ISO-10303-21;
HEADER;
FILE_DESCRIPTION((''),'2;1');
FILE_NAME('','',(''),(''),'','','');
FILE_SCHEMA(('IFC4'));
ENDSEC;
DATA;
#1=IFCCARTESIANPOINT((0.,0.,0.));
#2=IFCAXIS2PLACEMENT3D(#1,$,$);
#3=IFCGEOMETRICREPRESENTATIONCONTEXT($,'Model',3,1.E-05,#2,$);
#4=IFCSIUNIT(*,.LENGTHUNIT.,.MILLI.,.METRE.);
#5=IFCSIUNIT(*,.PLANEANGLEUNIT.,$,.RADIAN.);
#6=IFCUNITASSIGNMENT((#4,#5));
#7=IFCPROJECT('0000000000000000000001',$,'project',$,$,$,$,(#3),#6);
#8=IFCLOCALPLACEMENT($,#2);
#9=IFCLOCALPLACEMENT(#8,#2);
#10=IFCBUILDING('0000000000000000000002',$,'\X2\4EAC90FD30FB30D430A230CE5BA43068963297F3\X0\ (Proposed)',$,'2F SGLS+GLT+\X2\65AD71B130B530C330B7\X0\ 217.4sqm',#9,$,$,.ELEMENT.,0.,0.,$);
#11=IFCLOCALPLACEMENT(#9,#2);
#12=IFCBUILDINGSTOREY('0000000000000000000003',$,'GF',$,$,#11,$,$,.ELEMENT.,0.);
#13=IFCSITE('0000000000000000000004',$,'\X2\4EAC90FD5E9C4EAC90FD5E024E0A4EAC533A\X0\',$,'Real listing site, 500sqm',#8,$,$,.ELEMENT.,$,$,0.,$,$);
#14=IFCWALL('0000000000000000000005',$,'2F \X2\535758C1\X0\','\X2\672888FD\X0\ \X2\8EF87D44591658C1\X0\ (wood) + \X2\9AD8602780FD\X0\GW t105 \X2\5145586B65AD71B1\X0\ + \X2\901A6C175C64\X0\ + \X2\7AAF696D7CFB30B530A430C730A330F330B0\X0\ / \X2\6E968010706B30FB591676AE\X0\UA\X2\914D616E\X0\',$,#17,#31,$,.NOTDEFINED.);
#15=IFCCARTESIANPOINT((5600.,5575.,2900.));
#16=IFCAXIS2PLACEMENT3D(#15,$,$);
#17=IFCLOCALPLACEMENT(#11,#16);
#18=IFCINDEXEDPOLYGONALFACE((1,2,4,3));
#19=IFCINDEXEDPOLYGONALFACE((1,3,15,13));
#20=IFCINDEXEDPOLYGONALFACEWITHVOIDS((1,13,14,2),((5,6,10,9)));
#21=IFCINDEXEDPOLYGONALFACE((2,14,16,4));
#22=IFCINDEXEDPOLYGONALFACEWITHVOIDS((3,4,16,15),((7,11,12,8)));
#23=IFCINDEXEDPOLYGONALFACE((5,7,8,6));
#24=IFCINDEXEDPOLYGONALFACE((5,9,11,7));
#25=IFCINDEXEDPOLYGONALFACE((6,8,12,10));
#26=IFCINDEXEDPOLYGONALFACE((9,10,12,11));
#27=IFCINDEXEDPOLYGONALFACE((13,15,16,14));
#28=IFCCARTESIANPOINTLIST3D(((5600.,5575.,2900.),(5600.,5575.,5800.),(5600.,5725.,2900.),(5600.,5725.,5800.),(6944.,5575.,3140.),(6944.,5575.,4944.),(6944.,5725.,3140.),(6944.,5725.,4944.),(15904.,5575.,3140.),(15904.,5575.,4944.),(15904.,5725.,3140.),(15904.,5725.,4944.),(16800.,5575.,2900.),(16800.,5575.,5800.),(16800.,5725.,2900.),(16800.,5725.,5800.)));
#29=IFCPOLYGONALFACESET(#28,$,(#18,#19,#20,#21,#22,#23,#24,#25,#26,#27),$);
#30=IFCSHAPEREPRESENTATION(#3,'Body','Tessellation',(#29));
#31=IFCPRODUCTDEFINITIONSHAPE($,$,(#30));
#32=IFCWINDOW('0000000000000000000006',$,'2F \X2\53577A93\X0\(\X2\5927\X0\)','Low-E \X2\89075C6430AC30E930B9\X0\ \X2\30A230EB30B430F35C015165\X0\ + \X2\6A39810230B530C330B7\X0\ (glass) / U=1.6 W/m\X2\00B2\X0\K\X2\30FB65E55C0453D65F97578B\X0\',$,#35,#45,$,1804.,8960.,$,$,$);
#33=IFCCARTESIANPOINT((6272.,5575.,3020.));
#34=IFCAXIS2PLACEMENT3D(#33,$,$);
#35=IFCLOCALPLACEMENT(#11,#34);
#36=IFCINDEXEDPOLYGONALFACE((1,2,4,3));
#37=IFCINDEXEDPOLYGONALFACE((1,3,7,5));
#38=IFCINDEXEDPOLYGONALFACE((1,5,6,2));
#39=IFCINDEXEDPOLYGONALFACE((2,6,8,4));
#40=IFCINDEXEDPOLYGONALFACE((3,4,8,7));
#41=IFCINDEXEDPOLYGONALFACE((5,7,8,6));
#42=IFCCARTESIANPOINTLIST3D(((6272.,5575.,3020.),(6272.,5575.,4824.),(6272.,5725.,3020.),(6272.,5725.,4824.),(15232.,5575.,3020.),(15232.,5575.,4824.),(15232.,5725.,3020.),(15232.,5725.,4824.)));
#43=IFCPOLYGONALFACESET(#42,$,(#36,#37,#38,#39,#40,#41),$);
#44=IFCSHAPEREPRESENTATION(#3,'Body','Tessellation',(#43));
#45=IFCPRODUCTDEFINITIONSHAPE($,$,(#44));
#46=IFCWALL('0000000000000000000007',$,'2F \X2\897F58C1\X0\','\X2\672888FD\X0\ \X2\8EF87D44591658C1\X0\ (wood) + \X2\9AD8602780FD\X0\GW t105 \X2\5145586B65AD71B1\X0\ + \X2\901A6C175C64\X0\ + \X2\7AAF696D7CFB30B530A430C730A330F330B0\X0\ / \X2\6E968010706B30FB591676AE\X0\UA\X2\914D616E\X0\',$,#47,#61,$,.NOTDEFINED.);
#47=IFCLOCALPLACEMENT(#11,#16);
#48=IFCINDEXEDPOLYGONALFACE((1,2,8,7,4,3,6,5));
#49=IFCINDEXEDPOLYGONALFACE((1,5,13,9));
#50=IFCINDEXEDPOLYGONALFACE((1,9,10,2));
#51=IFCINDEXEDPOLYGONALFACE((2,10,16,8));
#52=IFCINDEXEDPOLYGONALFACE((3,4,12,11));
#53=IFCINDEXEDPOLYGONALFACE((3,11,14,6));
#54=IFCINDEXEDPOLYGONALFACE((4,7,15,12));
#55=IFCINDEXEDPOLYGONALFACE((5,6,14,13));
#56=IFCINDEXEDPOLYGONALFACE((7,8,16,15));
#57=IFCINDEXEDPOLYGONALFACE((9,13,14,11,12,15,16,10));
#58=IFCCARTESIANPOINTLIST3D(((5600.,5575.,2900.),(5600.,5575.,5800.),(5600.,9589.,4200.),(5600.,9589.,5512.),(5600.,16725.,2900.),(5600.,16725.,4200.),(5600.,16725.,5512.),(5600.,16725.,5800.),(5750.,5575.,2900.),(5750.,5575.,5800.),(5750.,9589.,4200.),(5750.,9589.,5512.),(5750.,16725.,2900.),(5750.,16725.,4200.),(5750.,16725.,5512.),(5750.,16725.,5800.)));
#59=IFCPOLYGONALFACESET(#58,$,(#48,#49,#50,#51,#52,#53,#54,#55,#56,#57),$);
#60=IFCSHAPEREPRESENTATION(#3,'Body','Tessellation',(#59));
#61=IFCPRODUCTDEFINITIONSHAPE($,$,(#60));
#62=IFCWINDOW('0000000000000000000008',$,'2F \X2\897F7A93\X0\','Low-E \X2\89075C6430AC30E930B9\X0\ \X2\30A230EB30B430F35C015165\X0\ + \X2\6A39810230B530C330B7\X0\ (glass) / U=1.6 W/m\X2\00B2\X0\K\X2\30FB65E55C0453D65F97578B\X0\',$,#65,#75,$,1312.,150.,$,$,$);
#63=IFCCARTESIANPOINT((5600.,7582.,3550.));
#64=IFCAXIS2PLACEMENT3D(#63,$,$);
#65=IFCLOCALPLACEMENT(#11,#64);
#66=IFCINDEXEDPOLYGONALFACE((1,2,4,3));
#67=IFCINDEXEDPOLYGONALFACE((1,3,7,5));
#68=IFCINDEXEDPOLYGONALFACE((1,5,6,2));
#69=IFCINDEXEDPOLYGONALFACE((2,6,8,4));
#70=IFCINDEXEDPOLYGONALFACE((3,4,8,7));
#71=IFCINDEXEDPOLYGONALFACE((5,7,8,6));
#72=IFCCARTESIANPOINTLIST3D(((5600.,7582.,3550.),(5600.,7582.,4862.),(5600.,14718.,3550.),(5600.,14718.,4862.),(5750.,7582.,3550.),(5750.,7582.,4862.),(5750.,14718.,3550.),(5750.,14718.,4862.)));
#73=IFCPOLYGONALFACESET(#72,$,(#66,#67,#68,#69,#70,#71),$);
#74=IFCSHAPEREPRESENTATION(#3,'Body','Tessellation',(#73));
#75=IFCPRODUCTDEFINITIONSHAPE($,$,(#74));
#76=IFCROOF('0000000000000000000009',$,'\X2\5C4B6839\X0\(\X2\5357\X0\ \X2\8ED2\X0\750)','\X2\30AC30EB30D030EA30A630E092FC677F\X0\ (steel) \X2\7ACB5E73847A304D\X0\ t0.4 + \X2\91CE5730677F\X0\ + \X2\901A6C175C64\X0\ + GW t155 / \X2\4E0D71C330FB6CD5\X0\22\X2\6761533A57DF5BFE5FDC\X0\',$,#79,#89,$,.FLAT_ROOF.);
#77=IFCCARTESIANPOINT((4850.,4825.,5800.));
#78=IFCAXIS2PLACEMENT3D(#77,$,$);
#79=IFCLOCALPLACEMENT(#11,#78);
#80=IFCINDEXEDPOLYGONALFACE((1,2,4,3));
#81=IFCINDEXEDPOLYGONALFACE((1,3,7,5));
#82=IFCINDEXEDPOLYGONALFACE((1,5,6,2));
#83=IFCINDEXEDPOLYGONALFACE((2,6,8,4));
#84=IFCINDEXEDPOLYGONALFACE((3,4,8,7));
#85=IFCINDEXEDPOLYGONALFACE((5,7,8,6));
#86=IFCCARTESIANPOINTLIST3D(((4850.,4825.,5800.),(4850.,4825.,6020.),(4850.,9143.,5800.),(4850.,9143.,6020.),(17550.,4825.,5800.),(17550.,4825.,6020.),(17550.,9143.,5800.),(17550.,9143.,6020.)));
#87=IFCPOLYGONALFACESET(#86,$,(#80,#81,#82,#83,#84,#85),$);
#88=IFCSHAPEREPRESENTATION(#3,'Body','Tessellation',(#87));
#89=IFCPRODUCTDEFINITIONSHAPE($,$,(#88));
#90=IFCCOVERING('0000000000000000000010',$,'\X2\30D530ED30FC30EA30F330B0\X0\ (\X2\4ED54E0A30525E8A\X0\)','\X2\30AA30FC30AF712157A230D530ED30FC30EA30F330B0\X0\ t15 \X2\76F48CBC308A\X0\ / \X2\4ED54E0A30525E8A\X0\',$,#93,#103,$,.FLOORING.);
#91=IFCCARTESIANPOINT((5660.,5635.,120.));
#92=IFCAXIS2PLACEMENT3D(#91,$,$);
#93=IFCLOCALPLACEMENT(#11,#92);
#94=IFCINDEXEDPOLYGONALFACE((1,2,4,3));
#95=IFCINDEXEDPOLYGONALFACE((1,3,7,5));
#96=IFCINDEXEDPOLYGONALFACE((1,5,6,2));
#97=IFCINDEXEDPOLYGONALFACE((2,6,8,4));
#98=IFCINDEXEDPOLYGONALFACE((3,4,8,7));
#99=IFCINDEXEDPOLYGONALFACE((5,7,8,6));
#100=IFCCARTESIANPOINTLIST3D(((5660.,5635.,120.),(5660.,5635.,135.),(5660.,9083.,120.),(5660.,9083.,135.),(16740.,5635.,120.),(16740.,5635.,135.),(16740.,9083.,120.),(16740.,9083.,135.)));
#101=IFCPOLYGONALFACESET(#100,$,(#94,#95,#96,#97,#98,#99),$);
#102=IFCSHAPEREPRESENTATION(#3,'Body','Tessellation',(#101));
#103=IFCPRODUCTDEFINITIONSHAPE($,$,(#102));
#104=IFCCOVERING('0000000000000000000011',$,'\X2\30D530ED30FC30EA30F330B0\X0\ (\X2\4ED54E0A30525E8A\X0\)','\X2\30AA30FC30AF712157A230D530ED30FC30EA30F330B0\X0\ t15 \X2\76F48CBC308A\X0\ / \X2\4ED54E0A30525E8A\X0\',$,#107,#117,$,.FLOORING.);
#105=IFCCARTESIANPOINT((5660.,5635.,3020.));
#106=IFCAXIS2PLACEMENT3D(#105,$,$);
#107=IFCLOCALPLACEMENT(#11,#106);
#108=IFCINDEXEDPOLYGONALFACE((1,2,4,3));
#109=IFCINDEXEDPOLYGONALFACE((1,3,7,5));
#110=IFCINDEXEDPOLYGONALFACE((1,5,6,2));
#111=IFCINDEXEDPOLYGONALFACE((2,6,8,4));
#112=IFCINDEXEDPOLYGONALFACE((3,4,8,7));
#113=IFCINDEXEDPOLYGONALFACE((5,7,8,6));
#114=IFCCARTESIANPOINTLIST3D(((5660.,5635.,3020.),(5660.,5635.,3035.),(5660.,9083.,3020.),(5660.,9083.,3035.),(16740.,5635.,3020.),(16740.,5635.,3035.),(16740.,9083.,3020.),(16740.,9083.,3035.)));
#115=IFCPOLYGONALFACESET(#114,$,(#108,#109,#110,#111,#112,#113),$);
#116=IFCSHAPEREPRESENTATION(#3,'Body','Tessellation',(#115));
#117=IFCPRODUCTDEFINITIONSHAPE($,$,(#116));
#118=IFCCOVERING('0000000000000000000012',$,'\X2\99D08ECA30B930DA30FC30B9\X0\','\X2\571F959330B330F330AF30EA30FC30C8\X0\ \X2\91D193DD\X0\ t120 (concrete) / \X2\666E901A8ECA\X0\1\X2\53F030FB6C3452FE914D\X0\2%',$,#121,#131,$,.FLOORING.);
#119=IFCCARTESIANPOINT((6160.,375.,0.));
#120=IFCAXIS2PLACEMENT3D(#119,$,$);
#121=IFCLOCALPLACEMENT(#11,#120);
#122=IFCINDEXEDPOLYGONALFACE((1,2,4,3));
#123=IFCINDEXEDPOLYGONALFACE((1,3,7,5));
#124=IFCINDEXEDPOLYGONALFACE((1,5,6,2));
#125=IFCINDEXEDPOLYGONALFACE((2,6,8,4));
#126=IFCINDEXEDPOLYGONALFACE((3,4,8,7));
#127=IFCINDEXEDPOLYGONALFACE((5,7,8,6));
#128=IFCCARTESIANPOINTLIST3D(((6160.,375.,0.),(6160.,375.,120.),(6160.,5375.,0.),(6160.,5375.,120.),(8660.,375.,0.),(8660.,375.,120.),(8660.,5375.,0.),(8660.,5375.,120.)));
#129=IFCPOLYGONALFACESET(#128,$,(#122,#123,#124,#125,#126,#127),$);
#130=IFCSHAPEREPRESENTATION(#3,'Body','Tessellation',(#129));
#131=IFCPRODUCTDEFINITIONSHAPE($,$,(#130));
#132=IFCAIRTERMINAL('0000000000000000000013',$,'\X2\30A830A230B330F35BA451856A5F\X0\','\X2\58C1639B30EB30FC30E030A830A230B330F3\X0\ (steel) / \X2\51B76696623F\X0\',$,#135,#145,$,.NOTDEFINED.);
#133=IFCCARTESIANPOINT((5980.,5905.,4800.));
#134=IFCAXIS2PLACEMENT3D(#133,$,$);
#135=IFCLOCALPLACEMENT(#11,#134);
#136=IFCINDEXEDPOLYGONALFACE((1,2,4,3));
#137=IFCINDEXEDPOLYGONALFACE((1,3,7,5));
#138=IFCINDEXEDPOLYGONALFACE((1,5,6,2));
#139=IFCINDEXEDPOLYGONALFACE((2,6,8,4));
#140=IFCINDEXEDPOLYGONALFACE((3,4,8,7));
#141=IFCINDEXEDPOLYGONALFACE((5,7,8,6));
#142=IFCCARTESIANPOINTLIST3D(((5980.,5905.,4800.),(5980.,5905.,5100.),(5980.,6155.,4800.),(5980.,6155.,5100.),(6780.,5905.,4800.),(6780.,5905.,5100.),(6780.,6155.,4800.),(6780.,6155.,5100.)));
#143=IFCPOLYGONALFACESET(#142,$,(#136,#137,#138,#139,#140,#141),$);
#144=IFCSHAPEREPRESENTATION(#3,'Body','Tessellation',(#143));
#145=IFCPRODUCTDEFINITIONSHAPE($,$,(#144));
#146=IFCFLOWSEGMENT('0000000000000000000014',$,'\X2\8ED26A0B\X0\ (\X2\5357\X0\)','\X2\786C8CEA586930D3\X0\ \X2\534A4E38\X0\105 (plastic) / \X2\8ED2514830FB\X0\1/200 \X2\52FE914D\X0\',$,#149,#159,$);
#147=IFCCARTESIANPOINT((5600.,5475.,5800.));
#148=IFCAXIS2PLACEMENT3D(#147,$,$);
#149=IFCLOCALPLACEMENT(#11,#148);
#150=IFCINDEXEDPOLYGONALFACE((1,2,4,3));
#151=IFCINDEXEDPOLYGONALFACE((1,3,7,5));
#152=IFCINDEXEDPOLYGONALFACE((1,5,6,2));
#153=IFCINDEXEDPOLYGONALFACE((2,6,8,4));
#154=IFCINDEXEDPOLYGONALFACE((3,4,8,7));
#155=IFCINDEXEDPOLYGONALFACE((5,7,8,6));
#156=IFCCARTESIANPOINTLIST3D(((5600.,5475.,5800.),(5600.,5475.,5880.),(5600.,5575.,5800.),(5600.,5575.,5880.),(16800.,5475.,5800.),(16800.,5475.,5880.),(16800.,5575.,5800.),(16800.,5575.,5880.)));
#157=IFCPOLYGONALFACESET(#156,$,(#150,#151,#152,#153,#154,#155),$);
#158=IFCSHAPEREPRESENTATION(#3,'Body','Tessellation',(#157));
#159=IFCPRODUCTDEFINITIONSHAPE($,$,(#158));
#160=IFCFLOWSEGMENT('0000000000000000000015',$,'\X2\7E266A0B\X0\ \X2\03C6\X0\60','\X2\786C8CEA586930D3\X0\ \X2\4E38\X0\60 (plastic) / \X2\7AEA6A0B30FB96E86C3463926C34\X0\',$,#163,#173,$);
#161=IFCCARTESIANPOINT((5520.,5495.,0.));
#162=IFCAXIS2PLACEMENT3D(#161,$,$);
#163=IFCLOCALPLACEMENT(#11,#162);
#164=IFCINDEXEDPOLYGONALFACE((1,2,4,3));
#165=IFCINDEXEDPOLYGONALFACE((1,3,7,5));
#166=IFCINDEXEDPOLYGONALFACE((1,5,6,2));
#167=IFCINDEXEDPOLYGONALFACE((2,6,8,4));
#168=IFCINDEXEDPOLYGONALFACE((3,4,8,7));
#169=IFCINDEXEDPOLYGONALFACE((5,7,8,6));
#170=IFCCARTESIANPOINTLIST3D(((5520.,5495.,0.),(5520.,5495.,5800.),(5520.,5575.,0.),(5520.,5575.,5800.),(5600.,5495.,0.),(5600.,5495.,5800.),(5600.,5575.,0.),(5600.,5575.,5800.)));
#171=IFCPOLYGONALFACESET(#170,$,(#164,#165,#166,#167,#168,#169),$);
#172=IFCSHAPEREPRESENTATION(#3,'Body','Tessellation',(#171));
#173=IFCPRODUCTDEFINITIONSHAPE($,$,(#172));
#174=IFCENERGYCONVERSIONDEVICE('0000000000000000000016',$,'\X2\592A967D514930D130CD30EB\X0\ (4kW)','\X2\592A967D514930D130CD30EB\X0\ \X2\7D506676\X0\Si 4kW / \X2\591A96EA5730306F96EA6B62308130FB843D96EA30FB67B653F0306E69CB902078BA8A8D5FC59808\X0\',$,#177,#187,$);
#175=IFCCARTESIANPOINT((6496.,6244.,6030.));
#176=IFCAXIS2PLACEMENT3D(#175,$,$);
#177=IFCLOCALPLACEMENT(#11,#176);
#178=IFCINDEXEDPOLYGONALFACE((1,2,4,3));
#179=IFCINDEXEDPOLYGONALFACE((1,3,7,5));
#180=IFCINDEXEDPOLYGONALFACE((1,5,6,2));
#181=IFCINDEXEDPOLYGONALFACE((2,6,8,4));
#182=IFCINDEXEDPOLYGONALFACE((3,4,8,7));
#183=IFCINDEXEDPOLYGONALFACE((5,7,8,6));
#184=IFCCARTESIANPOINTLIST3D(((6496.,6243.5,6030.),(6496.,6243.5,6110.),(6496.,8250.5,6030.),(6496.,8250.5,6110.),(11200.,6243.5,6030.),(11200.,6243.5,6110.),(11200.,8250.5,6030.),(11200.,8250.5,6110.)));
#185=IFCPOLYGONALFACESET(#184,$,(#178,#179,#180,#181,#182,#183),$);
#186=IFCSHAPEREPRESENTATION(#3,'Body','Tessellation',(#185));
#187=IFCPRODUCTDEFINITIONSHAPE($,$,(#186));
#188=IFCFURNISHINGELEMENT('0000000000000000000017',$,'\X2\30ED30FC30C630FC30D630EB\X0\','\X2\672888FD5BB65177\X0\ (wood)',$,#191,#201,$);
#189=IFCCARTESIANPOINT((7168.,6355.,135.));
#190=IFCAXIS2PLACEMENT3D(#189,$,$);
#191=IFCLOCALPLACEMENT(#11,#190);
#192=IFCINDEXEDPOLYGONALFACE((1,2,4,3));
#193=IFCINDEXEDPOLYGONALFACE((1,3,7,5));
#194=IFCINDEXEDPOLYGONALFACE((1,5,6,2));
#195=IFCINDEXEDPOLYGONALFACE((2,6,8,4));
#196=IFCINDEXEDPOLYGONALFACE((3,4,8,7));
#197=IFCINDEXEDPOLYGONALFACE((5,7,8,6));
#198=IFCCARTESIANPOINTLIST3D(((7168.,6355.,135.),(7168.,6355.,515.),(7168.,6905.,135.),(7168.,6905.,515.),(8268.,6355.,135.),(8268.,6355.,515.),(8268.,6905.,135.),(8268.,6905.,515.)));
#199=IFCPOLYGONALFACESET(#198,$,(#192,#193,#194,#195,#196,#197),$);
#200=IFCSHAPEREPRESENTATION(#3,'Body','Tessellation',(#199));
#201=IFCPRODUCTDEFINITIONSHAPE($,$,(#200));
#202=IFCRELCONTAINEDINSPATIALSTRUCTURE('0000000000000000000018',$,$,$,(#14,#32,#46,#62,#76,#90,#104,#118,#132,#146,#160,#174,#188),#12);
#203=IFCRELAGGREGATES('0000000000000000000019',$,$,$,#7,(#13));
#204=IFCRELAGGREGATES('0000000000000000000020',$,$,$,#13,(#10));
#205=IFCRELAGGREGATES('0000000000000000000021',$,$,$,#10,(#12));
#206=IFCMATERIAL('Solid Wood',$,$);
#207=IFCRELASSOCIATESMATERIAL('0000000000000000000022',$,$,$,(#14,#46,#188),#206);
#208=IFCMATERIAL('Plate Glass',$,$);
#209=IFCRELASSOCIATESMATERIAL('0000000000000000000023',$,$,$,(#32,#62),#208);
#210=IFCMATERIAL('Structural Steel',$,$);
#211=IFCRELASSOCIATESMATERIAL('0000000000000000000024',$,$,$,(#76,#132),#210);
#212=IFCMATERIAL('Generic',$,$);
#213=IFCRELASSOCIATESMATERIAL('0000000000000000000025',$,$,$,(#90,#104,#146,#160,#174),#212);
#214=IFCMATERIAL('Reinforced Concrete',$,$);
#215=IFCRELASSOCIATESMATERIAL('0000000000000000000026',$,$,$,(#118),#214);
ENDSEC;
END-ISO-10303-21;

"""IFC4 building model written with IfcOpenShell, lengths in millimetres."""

from ifc_helpers import new_model, si_unit, frame, frame_2d, origin, place, context, project, spatial, rectangle, extrude, material, element, fill, save


model = new_model("IFC4")

# Units and contexts
model_context = context("Model", 3, precision=1e-05, world=origin())
ifc_project = project(units=[si_unit("LENGTHUNIT", "METRE", prefix="MILLI"), si_unit("PLANEANGLEUNIT", "RADIAN")], contexts=[model_context])

# Site, building, storey
site_placement = place(None, origin())
site = spatial("IfcSite", under=ifc_project, at=site_placement, Name="京都府京都市上京区", ObjectType="Real listing site, 500sqm", CompositionType="ELEMENT", RefElevation=0.0)
building_placement = place(site_placement, origin())
building = spatial("IfcBuilding", under=site, at=building_placement, Name="京都・ピアノ室と防音 (Proposed)", ObjectType="2F SGLS+GLT+断熱サッシ 217.4sqm", CompositionType="ELEMENT", ElevationOfRefHeight=0.0, ElevationOfTerrain=0.0)
storey_placement = place(building_placement, origin())
storey = spatial("IfcBuildingStorey", under=building, at=storey_placement, Name="GF", CompositionType="ELEMENT", Elevation=0.0)

# Shared definitions
ifc_material_1 = material(Name="Solid Wood")

# Shared definitions
ifc_material_2 = material(Name="Reinforced Concrete")

# Shared definitions
ifc_material_3 = material(Name="Plate Glass")

# Walls, openings, windows
wall_1_placement = place(storey_placement, frame((5600.0, 5575.0, 2900.0)))
wall_1 = element("IfcWall", 1, at=wall_1_placement, inside=storey, material=ifc_material_1, Name="2F 南壁", Description="木製 軸組外壁 (wood) + 高性能GW t105 充填断熱 + 通気層 + 窯業系サイディング / 準耐火・外皮UA配慮", PredefinedType="NOTDEFINED", context=model_context, shape_type="SweptSolid", body=[
    extrude(rectangle(XDim=11200.0, YDim=150.0, at=frame_2d((5600.0, 75.0))), frame((5600.0, 5575.0, 2900.0)), (0.0, 0.0, 1.0), 2900.0),
])
opening_1_placement = place(storey_placement, frame((6272.0, 5575.0, 3020.0)))
opening_1 = element("IfcOpeningElement", 2, at=opening_1_placement, cuts=wall_1, PredefinedType="NOTDEFINED", context=model_context, shape_type="SweptSolid", body=[
    extrude(rectangle(XDim=8960.0, YDim=150.0, at=frame_2d((4480.0, 75.0))), frame((6272.0, 5575.0, 3020.0)), (0.0, 0.0, 1.0), 1804.0),
])
window_1_placement = place(storey_placement, frame((6272.0, 5575.0, 3020.0)))
window_1 = element("IfcWindow", 3, at=window_1_placement, inside=storey, material=ifc_material_3, Name="2F 南窓(大)", Description="Low-E 複層ガラス アルゴン封入 + 樹脂サッシ (glass) / U=1.6 W/m²K・日射取得型", OverallHeight=1804.0, OverallWidth=8960.0, context=model_context, shape_type="SweptSolid", body=[
    extrude(rectangle(XDim=8960.0, YDim=150.0, at=frame_2d((4480.0, 75.0))), frame((6272.0, 5575.0, 3020.0)), (0.0, 0.0, 1.0), 1804.0),
])
fill(opening_1, window_1)
wall_2_placement = place(storey_placement, frame((5600.0, 5575.0, 2900.0)))
wall_2 = element("IfcWall", 4, at=wall_2_placement, inside=storey, material=ifc_material_1, Name="2F 西壁", Description="木製 軸組外壁 (wood) + 高性能GW t105 充填断熱 + 通気層 + 窯業系サイディング / 準耐火・外皮UA配慮", PredefinedType="NOTDEFINED", context=model_context, shape_type="SweptSolid", body=[
    extrude(rectangle(XDim=150.0, YDim=11150.0, at=frame_2d((75.0, 5575.0))), frame((5600.0, 5575.0, 2900.0)), (0.0, 0.0, 1.0), 2900.0),
])
opening_2_placement = place(storey_placement, frame((5600.0, 7582.0, 3550.0)))
opening_2 = element("IfcOpeningElement", 5, at=opening_2_placement, cuts=wall_2, PredefinedType="NOTDEFINED", context=model_context, shape_type="SweptSolid", body=[
    extrude(rectangle(XDim=150.0, YDim=7136.0, at=frame_2d((75.0, 3568.0))), frame((5600.0, 7582.0, 3550.0)), (0.0, 0.0, 1.0), 1312.0),
])
window_2_placement = place(storey_placement, frame((5600.0, 7582.0, 3550.0)))
window_2 = element("IfcWindow", 6, at=window_2_placement, inside=storey, material=ifc_material_3, Name="2F 西窓", Description="Low-E 複層ガラス アルゴン封入 + 樹脂サッシ (glass) / U=1.6 W/m²K・日射取得型", OverallHeight=1312.0, OverallWidth=150.0, context=model_context, shape_type="SweptSolid", body=[
    extrude(rectangle(XDim=150.0, YDim=7136.0, at=frame_2d((75.0, 3568.0))), frame((5600.0, 7582.0, 3550.0)), (0.0, 0.0, 1.0), 1312.0),
])
fill(opening_2, window_2)

# Roof
ifc_material_4 = material(Name="Structural Steel")
for number, where, name in (
    (7, (4850.0, 4825.0, 5800.0), "屋根(南 軒750)"),
):
    element("IfcRoof", number, at=place(storey_placement, frame(where)), inside=storey, material=ifc_material_4, Name=name, Description="ガルバリウム鋼板 (steel) 立平葺き t0.4 + 野地板 + 通気層 + GW t155 / 不燃・法22条区域対応", PredefinedType="FLAT_ROOF", context=model_context, shape_type="SweptSolid", body=[
        extrude(rectangle(XDim=12700.0, YDim=4318.0, at=frame_2d((6350.0, 2159.0))), frame((4850.0, 4825.0, 5800.0)), (0.0, 0.0, 1.0), 220.0),
    ])

# Coverings
ifc_material_5 = material(Name="Generic")
covering_1_placement = place(storey_placement, frame((5660.0, 5635.0, 120.0)))
element("IfcCovering", 8, at=covering_1_placement, inside=storey, material=ifc_material_5, Name="フローリング (仕上げ床)", Description="オーク無垢フローリング t15 直貼り / 仕上げ床", PredefinedType="FLOORING", context=model_context, shape_type="SweptSolid", body=[
    extrude(rectangle(XDim=11080.0, YDim=3448.0, at=frame_2d((5540.0, 1724.0))), frame((5660.0, 5635.0, 120.0)), (0.0, 0.0, 1.0), 15.0),
])
covering_2_placement = place(storey_placement, frame((5660.0, 5635.0, 3020.0)))
element("IfcCovering", 9, at=covering_2_placement, inside=storey, material=ifc_material_5, Name="フローリング (仕上げ床)", Description="オーク無垢フローリング t15 直貼り / 仕上げ床", PredefinedType="FLOORING", context=model_context, shape_type="SweptSolid", body=[
    extrude(rectangle(XDim=11080.0, YDim=3448.0, at=frame_2d((5540.0, 1724.0))), frame((5660.0, 5635.0, 3020.0)), (0.0, 0.0, 1.0), 15.0),
])
covering_3_placement = place(storey_placement, frame((6160.0, 375.0, 0.0)))
element("IfcCovering", 10, at=covering_3_placement, inside=storey, material=ifc_material_2, Name="駐車スペース", Description="土間コンクリート 金鏝 t120 (concrete) / 普通車1台・水勾配2%", PredefinedType="FLOORING", context=model_context, shape_type="SweptSolid", body=[
    extrude(rectangle(XDim=2500.0, YDim=5000.0, at=frame_2d((1250.0, 2500.0))), frame((6160.0, 375.0, 0.0)), (0.0, 0.0, 1.0), 120.0),
])

# Air terminal
air_terminal_placement = place(storey_placement, frame((5980.0, 5905.0, 4800.0)))
element("IfcAirTerminal", 11, at=air_terminal_placement, inside=storey, material=ifc_material_4, Name="エアコン室内機", Description="壁掛ルームエアコン (steel) / 冷暖房", PredefinedType="NOTDEFINED", context=model_context, shape_type="SweptSolid", body=[
    extrude(rectangle(XDim=800.0, YDim=250.0, at=frame_2d((400.0, 125.0))), frame((5980.0, 5905.0, 4800.0)), (0.0, 0.0, 1.0), 300.0),
])

# Flow segments
flow_segment_1_placement = place(storey_placement, frame((5600.0, 5475.0, 5800.0)))
element("IfcFlowSegment", 12, at=flow_segment_1_placement, inside=storey, material=ifc_material_5, Name="軒樋 (南)", Description="硬質塩ビ 半丸105 (plastic) / 軒先・1/200 勾配", context=model_context, shape_type="SweptSolid", body=[
    extrude(rectangle(XDim=11200.0, YDim=100.0, at=frame_2d((5600.0, 50.0))), frame((5600.0, 5475.0, 5800.0)), (0.0, 0.0, 1.0), 80.0),
])
flow_segment_2_placement = place(storey_placement, frame((5520.0, 5495.0, 0.0)))
element("IfcFlowSegment", 13, at=flow_segment_2_placement, inside=storey, material=ifc_material_5, Name="縦樋 φ60", Description="硬質塩ビ 丸60 (plastic) / 竪樋・雨水排水", context=model_context, shape_type="SweptSolid", body=[
    extrude(rectangle(XDim=80.0, YDim=80.0, at=frame_2d((40.0, 40.0))), frame((5520.0, 5495.0, 0.0)), (0.0, 0.0, 1.0), 5800.0),
])

# Energy conversion device
energy_conversion_device_placement = place(storey_placement, frame((6496.0, 6244.0, 6030.0)))
element("IfcEnergyConversionDevice", 14, at=energy_conversion_device_placement, inside=storey, material=ifc_material_5, Name="太陽光パネル (4kW)", Description="太陽光パネル 結晶Si 4kW / 多雪地は雪止め・落雪・架台の構造確認必須", context=model_context, shape_type="SweptSolid", body=[
    extrude(rectangle(XDim=4704.0, YDim=2007.0, at=frame_2d((2352.0, 1003.0))), frame((6496.0, 6244.0, 6030.0)), (0.0, 0.0, 1.0), 80.0),
])

# Furnishing element
furnishing_1_placement = place(storey_placement, frame((7168.0, 6355.0, 135.0)))
element("IfcFurnishingElement", 15, at=furnishing_1_placement, inside=storey, material=ifc_material_1, Name="ローテーブル", Description="木製家具 (wood)", context=model_context, shape_type="SweptSolid", body=[
    extrude(rectangle(XDim=1100.0, YDim=550.0, at=frame_2d((550.0, 275.0))), frame((7168.0, 6355.0, 135.0)), (0.0, 0.0, 1.0), 380.0),
])

save(model, "model.ifc")
